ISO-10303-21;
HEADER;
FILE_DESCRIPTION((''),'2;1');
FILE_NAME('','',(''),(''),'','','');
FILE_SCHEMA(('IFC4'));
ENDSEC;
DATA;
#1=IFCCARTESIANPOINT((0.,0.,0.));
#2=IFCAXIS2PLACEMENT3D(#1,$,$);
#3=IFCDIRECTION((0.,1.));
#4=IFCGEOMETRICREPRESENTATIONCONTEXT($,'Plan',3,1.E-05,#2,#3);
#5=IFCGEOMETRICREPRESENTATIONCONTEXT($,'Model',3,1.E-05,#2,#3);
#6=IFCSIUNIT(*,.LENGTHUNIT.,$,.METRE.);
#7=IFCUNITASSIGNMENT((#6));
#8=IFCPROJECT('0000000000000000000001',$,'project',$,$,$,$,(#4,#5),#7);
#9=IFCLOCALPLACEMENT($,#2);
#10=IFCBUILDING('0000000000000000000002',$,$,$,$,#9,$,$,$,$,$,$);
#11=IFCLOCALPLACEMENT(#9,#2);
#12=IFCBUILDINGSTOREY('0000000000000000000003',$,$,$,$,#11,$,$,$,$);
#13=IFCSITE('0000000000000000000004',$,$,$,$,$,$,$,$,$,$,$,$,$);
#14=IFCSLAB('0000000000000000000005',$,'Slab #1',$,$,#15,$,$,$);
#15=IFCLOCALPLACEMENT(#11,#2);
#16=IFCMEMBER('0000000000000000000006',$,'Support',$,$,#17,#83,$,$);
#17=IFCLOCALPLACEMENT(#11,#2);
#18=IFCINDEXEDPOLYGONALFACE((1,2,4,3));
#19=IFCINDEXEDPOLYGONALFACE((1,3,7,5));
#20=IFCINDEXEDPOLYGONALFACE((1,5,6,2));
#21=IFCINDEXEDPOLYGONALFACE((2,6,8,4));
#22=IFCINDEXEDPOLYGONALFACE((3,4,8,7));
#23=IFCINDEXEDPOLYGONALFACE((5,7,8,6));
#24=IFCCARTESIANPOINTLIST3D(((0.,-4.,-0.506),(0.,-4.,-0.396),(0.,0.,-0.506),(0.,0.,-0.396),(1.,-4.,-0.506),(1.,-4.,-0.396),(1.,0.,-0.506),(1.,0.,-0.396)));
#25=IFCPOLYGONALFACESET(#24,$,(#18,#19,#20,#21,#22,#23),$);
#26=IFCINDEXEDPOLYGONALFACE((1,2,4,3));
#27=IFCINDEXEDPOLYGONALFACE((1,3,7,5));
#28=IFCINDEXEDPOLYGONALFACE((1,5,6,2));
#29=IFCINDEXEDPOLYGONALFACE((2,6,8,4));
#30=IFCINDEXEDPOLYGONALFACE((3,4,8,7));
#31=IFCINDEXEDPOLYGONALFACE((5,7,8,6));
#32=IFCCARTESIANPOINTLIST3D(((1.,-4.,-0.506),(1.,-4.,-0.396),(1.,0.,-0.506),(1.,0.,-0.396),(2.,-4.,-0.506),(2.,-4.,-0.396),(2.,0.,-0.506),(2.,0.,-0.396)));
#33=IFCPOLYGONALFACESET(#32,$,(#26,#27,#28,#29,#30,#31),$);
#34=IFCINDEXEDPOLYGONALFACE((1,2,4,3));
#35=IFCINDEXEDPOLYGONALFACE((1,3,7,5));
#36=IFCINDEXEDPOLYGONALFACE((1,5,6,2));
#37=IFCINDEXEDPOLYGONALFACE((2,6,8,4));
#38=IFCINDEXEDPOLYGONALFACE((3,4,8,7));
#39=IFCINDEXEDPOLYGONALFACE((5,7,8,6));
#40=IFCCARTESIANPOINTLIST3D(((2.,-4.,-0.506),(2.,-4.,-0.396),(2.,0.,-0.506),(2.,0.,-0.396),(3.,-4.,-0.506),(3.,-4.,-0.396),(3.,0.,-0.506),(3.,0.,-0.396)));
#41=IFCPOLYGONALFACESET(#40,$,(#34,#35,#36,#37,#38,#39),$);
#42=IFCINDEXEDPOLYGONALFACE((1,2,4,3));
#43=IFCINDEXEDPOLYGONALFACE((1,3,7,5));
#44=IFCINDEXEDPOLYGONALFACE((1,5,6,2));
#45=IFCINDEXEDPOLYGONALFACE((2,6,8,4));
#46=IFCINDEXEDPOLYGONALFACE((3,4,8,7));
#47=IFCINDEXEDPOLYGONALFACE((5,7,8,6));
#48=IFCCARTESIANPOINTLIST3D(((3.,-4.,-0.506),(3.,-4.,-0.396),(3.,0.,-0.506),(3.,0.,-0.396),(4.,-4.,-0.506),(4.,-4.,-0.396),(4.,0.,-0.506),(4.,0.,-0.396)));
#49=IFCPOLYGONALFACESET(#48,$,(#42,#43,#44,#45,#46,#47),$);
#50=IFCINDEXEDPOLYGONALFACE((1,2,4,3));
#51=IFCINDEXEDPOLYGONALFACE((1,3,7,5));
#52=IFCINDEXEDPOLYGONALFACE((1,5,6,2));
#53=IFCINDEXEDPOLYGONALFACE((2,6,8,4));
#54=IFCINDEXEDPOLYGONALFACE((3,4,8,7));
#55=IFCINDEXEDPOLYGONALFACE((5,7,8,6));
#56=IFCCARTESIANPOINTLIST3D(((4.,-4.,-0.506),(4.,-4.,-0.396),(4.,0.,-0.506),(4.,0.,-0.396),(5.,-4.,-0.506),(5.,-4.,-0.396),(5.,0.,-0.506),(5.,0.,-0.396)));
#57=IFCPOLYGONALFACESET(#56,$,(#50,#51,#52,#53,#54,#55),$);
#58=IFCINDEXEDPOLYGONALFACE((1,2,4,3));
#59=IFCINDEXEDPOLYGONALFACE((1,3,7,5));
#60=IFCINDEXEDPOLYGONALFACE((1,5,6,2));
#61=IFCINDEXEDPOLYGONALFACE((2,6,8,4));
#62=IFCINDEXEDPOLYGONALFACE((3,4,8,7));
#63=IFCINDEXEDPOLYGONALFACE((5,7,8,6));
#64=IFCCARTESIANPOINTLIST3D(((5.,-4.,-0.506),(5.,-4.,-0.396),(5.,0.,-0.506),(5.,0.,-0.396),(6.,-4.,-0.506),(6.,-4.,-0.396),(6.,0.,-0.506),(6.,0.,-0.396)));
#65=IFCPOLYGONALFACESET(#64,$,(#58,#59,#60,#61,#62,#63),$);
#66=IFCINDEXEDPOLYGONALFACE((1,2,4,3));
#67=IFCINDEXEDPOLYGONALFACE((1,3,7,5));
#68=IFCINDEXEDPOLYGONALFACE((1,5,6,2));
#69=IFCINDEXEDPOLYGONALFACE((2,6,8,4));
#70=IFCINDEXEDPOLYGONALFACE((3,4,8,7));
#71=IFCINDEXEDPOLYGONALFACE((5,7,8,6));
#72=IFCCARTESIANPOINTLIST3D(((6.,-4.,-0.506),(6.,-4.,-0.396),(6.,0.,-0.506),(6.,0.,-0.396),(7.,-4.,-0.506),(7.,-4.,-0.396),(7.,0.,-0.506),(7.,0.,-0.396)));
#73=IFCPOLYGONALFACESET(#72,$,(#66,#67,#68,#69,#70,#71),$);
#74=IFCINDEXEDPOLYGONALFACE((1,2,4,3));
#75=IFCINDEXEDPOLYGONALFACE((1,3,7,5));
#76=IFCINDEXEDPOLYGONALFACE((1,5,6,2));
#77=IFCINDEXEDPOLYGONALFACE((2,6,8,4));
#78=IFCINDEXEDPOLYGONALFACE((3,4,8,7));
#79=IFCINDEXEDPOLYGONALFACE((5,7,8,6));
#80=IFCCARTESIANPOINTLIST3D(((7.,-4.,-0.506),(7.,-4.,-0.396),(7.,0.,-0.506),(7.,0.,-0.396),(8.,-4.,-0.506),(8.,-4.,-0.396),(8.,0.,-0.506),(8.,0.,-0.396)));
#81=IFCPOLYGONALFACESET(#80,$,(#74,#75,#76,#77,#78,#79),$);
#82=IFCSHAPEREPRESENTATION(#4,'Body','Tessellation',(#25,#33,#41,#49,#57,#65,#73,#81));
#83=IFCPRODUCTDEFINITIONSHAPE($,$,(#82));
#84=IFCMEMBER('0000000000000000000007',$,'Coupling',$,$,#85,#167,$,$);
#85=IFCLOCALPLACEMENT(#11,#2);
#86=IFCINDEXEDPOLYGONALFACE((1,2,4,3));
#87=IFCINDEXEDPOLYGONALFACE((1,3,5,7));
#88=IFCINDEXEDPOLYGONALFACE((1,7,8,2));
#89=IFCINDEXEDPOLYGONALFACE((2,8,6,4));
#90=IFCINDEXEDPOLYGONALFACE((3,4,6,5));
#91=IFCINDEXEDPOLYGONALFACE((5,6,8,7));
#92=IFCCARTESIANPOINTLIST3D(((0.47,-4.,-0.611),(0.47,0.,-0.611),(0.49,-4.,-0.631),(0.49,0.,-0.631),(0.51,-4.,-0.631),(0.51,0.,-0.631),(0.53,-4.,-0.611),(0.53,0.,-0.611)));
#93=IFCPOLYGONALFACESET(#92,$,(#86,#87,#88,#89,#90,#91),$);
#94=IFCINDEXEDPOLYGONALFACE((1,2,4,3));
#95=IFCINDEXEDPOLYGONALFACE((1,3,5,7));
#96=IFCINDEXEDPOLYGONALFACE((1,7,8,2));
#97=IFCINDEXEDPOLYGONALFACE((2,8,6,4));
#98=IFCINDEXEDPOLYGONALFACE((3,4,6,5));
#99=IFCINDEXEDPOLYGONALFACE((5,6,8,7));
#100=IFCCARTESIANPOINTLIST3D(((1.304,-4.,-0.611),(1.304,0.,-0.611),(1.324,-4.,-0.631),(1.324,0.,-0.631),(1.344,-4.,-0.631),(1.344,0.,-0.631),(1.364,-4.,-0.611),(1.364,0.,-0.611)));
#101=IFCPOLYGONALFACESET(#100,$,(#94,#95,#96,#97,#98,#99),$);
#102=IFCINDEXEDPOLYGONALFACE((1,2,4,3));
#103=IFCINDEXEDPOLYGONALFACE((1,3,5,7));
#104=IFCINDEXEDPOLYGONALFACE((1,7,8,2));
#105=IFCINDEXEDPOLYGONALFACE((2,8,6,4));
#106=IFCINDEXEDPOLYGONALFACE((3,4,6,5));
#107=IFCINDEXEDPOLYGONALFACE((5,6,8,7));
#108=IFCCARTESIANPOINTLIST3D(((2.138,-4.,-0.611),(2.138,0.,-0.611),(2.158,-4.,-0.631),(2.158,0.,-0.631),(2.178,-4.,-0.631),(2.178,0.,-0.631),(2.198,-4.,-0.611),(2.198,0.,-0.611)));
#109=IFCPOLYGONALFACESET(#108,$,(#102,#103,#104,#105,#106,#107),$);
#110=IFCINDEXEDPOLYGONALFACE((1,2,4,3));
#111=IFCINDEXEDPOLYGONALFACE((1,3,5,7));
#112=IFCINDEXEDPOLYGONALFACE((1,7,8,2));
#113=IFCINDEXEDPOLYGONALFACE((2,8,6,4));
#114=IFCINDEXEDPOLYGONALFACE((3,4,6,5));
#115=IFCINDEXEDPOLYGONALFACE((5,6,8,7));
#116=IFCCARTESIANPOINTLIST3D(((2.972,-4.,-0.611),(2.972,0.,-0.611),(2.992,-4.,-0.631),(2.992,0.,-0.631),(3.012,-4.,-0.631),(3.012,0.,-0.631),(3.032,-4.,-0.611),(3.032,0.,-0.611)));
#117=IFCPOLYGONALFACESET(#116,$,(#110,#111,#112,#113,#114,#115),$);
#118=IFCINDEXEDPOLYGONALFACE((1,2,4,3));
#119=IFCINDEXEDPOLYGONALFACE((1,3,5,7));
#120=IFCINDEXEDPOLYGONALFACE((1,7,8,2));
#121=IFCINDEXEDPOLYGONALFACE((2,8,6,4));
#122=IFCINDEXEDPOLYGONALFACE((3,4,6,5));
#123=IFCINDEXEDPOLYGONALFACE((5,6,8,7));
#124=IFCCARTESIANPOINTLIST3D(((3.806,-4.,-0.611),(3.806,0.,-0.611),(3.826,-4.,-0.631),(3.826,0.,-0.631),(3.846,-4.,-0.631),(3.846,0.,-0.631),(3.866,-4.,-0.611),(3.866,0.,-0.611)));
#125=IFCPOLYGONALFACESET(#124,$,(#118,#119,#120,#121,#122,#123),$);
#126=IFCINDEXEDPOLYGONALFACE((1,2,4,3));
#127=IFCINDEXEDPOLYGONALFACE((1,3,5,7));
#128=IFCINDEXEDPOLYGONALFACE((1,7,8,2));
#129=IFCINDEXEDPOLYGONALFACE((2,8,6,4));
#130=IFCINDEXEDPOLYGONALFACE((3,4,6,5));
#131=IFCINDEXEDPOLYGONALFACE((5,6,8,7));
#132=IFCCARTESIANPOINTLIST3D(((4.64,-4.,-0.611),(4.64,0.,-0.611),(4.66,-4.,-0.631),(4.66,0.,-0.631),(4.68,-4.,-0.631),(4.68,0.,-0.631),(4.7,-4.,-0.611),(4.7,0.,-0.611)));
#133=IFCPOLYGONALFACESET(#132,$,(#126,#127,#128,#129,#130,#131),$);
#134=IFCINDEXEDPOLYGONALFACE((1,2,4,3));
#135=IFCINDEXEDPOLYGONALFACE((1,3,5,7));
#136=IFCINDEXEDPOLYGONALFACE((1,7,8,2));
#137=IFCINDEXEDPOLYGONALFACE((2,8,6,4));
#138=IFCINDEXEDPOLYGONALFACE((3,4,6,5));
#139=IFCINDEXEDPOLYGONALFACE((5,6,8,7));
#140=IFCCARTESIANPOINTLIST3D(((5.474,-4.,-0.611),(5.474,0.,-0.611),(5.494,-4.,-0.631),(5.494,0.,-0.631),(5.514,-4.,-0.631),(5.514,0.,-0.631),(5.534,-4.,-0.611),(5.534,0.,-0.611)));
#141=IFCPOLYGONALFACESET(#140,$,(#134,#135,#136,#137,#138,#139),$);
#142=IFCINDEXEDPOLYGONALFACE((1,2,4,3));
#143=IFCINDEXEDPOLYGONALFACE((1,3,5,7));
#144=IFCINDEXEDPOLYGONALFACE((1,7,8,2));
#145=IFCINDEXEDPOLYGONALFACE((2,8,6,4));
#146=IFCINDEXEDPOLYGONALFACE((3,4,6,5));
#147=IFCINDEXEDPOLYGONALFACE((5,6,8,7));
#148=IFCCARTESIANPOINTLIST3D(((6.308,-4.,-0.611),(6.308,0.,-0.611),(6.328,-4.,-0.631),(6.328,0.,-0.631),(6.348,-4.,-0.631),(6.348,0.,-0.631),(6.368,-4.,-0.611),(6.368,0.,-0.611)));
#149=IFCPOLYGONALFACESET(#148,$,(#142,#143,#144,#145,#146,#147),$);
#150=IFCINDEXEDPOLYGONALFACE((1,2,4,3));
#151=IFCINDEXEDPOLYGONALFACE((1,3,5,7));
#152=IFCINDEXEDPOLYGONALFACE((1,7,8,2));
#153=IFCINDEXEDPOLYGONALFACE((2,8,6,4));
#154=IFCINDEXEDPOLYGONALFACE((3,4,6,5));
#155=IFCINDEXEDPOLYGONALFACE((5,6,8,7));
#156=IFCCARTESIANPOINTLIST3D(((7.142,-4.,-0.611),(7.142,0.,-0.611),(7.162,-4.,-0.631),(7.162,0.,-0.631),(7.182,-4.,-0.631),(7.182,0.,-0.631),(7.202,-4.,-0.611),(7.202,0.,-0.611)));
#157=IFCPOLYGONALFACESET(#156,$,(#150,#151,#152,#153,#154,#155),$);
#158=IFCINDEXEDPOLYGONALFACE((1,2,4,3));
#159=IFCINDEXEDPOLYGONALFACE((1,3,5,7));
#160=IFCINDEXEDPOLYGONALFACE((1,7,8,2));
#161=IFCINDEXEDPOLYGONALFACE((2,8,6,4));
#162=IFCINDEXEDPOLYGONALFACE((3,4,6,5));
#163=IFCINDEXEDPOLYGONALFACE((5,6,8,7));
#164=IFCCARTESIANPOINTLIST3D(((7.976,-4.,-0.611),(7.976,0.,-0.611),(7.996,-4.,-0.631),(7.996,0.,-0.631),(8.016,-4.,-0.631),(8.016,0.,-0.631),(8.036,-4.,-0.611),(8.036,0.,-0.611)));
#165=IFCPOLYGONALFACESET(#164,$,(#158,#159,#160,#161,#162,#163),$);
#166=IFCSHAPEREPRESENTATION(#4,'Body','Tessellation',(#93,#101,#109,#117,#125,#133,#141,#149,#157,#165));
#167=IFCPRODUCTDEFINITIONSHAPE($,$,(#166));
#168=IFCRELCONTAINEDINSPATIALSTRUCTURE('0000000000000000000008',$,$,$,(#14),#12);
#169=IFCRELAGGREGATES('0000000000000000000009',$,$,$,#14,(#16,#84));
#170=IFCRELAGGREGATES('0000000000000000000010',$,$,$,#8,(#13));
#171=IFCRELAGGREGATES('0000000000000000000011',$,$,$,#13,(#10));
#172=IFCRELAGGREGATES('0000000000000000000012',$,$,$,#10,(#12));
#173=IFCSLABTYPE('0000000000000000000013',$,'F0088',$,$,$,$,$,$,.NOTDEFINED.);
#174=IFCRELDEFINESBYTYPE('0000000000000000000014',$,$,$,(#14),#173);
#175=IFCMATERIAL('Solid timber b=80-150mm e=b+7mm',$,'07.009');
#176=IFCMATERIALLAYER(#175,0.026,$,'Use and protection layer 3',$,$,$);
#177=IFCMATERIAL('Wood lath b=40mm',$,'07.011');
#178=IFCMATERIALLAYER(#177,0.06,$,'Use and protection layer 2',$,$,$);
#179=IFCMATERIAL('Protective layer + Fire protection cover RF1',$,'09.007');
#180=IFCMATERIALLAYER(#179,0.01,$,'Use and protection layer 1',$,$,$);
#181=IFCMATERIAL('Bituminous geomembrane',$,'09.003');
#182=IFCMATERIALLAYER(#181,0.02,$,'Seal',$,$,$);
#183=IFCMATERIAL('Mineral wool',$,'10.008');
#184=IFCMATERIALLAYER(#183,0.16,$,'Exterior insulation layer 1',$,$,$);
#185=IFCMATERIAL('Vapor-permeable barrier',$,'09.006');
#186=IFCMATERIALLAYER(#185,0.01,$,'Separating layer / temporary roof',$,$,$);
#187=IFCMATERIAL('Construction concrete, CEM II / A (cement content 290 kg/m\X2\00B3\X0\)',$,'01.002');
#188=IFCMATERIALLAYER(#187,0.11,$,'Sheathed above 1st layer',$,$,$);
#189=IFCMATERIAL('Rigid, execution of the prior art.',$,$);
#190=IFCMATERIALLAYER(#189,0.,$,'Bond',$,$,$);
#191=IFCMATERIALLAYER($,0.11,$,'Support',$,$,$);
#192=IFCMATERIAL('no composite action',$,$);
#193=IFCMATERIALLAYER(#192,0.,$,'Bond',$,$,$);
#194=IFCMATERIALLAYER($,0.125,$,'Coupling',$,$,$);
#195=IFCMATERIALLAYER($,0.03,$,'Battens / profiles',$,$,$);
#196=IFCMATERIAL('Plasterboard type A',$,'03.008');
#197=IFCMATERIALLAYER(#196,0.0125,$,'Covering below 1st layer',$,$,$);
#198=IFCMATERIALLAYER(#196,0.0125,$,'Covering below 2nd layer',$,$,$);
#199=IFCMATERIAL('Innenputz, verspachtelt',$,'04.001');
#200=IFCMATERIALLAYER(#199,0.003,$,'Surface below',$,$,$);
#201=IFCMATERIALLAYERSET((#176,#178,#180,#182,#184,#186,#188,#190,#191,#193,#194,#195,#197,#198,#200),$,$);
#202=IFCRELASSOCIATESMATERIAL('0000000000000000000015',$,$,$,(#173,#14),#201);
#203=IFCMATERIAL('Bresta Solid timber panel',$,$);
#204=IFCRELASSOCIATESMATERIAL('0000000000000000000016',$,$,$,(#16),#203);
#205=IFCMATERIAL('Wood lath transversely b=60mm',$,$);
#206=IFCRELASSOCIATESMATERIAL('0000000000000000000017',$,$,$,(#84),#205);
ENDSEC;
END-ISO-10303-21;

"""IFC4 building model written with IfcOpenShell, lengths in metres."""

from ifc_helpers import new_model, si_unit, direction, frame, frame_2d, origin, place, context, project, spatial, polyline, rectangle, outline, extrude, material, layer, layer_set, type_object, element, aggregate, save


model = new_model("IFC4")

# Units and contexts
plan_context = context("Plan", 3, precision=1e-05, world=origin(), true_north=direction((0.0, 1.0)))
model_context = context("Model", 3, precision=1e-05, world=origin(), true_north=direction((0.0, 1.0)))
ifc_project = project(units=[si_unit("LENGTHUNIT", "METRE")], contexts=[plan_context, model_context])

# Site, building, storey
site = spatial("IfcSite", under=ifc_project)
building_placement = place(None, origin())
building = spatial("IfcBuilding", under=site, at=building_placement)
storey_placement = place(building_placement, origin())
storey = spatial("IfcBuildingStorey", under=building, at=storey_placement)

# Slab, members
ifc_material_1 = material(Name="Solid timber b=80-150mm e=b+7mm", Category="07.009")
ifc_layer_1 = layer(ifc_material_1, 0.026, Name="Use and protection layer 3")
ifc_material_2 = material(Name="Wood lath b=40mm", Category="07.011")
ifc_layer_2 = layer(ifc_material_2, 0.06, Name="Use and protection layer 2")
ifc_material_3 = material(Name="Protective layer + Fire protection cover RF1", Category="09.007")
ifc_layer_3 = layer(ifc_material_3, 0.01, Name="Use and protection layer 1")
ifc_material_4 = material(Name="Bituminous geomembrane", Category="09.003")
ifc_layer_4 = layer(ifc_material_4, 0.02, Name="Seal")
ifc_material_5 = material(Name="Mineral wool", Category="10.008")
ifc_layer_5 = layer(ifc_material_5, 0.16, Name="Exterior insulation layer 1")
ifc_material_6 = material(Name="Vapor-permeable barrier", Category="09.006")
ifc_layer_6 = layer(ifc_material_6, 0.01, Name="Separating layer / temporary roof")
ifc_material_7 = material(Name="Construction concrete, CEM II / A (cement content 290 kg/m³)", Category="01.002")
ifc_layer_7 = layer(ifc_material_7, 0.11, Name="Sheathed above 1st layer")
ifc_material_8 = material(Name="Rigid, execution of the prior art.")
ifc_layer_8 = layer(ifc_material_8, 0.0, Name="Bond")
ifc_layer_9 = layer(None, 0.11, Name="Support")
ifc_material_9 = material(Name="no composite action")
ifc_layer_10 = layer(ifc_material_9, 0.0, Name="Bond")
ifc_layer_11 = layer(None, 0.125, Name="Coupling")
ifc_layer_12 = layer(None, 0.03, Name="Battens / profiles")
ifc_material_10 = material(Name="Plasterboard type A", Category="03.008")
ifc_layer_13 = layer(ifc_material_10, 0.0125, Name="Covering below 1st layer")
ifc_layer_14 = layer(ifc_material_10, 0.0125, Name="Covering below 2nd layer")
ifc_material_11 = material(Name="Innenputz, verspachtelt", Category="04.001")
ifc_layer_15 = layer(ifc_material_11, 0.003, Name="Surface below")
ifc_layer_set = layer_set([ifc_layer_1, ifc_layer_2, ifc_layer_3, ifc_layer_4, ifc_layer_5, ifc_layer_6, ifc_layer_7, ifc_layer_8, ifc_layer_9, ifc_layer_10, ifc_layer_11, ifc_layer_12, ifc_layer_13, ifc_layer_14, ifc_layer_15])
slab_type = type_object("IfcSlabType", Name="F0088", PredefinedType="NOTDEFINED", material=ifc_layer_set)
slab_placement = place(None, frame((0.0, 0.0, 0.0), z_axis=(0.0, 0.0, -1.0), x_axis=(1.0, 0.0, 0.0)))
slab = element("IfcSlab", 1, at=slab_placement, inside=storey, type_object=slab_type, material=ifc_layer_set, Name="Slab #1")
ifc_material_12 = material(Name="Bresta Solid timber panel")
member_1_placement = place(slab_placement, origin())
member_1 = element("IfcMember", 2, at=member_1_placement, material=ifc_material_12, Name="Support", context=plan_context, shape_type="SweptSolid", body=[
    extrude(rectangle(XDim=1.0, YDim=0.11, at=frame_2d((0.5, 0.055), x_axis=(1.0, 0.0))), frame((0.0, 4.0, 0.396), z_axis=(0.0, -1.0, 0.0), x_axis=(1.0, 0.0, 0.0)), (0.0, 0.0, 1.0), 4.0),
    extrude(rectangle(XDim=1.0, YDim=0.11, at=frame_2d((0.5, 0.055), x_axis=(1.0, 0.0))), frame((1.0, 4.0, 0.396), z_axis=(0.0, -1.0, 0.0), x_axis=(1.0, 0.0, 0.0)), (0.0, 0.0, 1.0), 4.0),
    extrude(rectangle(XDim=1.0, YDim=0.11, at=frame_2d((0.5, 0.055), x_axis=(1.0, 0.0))), frame((2.0, 4.0, 0.396), z_axis=(0.0, -1.0, 0.0), x_axis=(1.0, 0.0, 0.0)), (0.0, 0.0, 1.0), 4.0),
    extrude(rectangle(XDim=1.0, YDim=0.11, at=frame_2d((0.5, 0.055), x_axis=(1.0, 0.0))), frame((3.0, 4.0, 0.396), z_axis=(0.0, -1.0, 0.0), x_axis=(1.0, 0.0, 0.0)), (0.0, 0.0, 1.0), 4.0),
    extrude(rectangle(XDim=1.0, YDim=0.11, at=frame_2d((0.5, 0.055), x_axis=(1.0, 0.0))), frame((4.0, 4.0, 0.396), z_axis=(0.0, -1.0, 0.0), x_axis=(1.0, 0.0, 0.0)), (0.0, 0.0, 1.0), 4.0),
    extrude(rectangle(XDim=1.0, YDim=0.11, at=frame_2d((0.5, 0.055), x_axis=(1.0, 0.0))), frame((5.0, 4.0, 0.396), z_axis=(0.0, -1.0, 0.0), x_axis=(1.0, 0.0, 0.0)), (0.0, 0.0, 1.0), 4.0),
    extrude(rectangle(XDim=1.0, YDim=0.11, at=frame_2d((0.5, 0.055), x_axis=(1.0, 0.0))), frame((6.0, 4.0, 0.396), z_axis=(0.0, -1.0, 0.0), x_axis=(1.0, 0.0, 0.0)), (0.0, 0.0, 1.0), 4.0),
    extrude(rectangle(XDim=1.0, YDim=0.11, at=frame_2d((0.5, 0.055), x_axis=(1.0, 0.0))), frame((7.0, 4.0, 0.396), z_axis=(0.0, -1.0, 0.0), x_axis=(1.0, 0.0, 0.0)), (0.0, 0.0, 1.0), 4.0),
])
ifc_material_13 = material(Name="Wood lath transversely b=60mm")
member_2_placement = place(slab_placement, origin())
member_2 = element("IfcMember", 3, at=member_2_placement, material=ifc_material_13, Name="Coupling", context=plan_context, shape_type="SweptSolid", body=[
    extrude(outline(polyline([(0.0, 0.0), (0.06, 0.0), (0.04, 0.02), (0.02, 0.02), (0.0, 0.0)])), frame((0.47, 4.0, 0.611), z_axis=(0.0, -1.0, 0.0), x_axis=(1.0, 0.0, 0.0)), (0.0, 0.0, 1.0), 4.0),
    extrude(outline(polyline([(0.0, 0.0), (0.06, 0.0), (0.04, 0.02), (0.02, 0.02), (0.0, 0.0)])), frame((1.304, 4.0, 0.611), z_axis=(0.0, -1.0, 0.0), x_axis=(1.0, 0.0, 0.0)), (0.0, 0.0, 1.0), 4.0),
    extrude(outline(polyline([(0.0, 0.0), (0.06, 0.0), (0.04, 0.02), (0.02, 0.02), (0.0, 0.0)])), frame((2.138, 4.0, 0.611), z_axis=(0.0, -1.0, 0.0), x_axis=(1.0, 0.0, 0.0)), (0.0, 0.0, 1.0), 4.0),
    extrude(outline(polyline([(0.0, 0.0), (0.06, 0.0), (0.04, 0.02), (0.02, 0.02), (0.0, 0.0)])), frame((2.972, 4.0, 0.611), z_axis=(0.0, -1.0, 0.0), x_axis=(1.0, 0.0, 0.0)), (0.0, 0.0, 1.0), 4.0),
    extrude(outline(polyline([(0.0, 0.0), (0.06, 0.0), (0.04, 0.02), (0.02, 0.02), (0.0, 0.0)])), frame((3.806, 4.0, 0.611), z_axis=(0.0, -1.0, 0.0), x_axis=(1.0, 0.0, 0.0)), (0.0, 0.0, 1.0), 4.0),
    extrude(outline(polyline([(0.0, 0.0), (0.06, 0.0), (0.04, 0.02), (0.02, 0.02), (0.0, 0.0)])), frame((4.64, 4.0, 0.611), z_axis=(0.0, -1.0, 0.0), x_axis=(1.0, 0.0, 0.0)), (0.0, 0.0, 1.0), 4.0),
    extrude(outline(polyline([(0.0, 0.0), (0.06, 0.0), (0.04, 0.02), (0.02, 0.02), (0.0, 0.0)])), frame((5.474, 4.0, 0.611), z_axis=(0.0, -1.0, 0.0), x_axis=(1.0, 0.0, 0.0)), (0.0, 0.0, 1.0), 4.0),
    extrude(outline(polyline([(0.0, 0.0), (0.06, 0.0), (0.04, 0.02), (0.02, 0.02), (0.0, 0.0)])), frame((6.308, 4.0, 0.611), z_axis=(0.0, -1.0, 0.0), x_axis=(1.0, 0.0, 0.0)), (0.0, 0.0, 1.0), 4.0),
    extrude(outline(polyline([(0.0, 0.0), (0.06, 0.0), (0.04, 0.02), (0.02, 0.02), (0.0, 0.0)])), frame((7.142, 4.0, 0.611), z_axis=(0.0, -1.0, 0.0), x_axis=(1.0, 0.0, 0.0)), (0.0, 0.0, 1.0), 4.0),
    extrude(outline(polyline([(0.0, 0.0), (0.06, 0.0), (0.04, 0.02), (0.02, 0.02), (0.0, 0.0)])), frame((7.976, 4.0, 0.611), z_axis=(0.0, -1.0, 0.0), x_axis=(1.0, 0.0, 0.0)), (0.0, 0.0, 1.0), 4.0),
])
aggregate(slab, [member_1, member_2])

save(model, "model.ifc")
